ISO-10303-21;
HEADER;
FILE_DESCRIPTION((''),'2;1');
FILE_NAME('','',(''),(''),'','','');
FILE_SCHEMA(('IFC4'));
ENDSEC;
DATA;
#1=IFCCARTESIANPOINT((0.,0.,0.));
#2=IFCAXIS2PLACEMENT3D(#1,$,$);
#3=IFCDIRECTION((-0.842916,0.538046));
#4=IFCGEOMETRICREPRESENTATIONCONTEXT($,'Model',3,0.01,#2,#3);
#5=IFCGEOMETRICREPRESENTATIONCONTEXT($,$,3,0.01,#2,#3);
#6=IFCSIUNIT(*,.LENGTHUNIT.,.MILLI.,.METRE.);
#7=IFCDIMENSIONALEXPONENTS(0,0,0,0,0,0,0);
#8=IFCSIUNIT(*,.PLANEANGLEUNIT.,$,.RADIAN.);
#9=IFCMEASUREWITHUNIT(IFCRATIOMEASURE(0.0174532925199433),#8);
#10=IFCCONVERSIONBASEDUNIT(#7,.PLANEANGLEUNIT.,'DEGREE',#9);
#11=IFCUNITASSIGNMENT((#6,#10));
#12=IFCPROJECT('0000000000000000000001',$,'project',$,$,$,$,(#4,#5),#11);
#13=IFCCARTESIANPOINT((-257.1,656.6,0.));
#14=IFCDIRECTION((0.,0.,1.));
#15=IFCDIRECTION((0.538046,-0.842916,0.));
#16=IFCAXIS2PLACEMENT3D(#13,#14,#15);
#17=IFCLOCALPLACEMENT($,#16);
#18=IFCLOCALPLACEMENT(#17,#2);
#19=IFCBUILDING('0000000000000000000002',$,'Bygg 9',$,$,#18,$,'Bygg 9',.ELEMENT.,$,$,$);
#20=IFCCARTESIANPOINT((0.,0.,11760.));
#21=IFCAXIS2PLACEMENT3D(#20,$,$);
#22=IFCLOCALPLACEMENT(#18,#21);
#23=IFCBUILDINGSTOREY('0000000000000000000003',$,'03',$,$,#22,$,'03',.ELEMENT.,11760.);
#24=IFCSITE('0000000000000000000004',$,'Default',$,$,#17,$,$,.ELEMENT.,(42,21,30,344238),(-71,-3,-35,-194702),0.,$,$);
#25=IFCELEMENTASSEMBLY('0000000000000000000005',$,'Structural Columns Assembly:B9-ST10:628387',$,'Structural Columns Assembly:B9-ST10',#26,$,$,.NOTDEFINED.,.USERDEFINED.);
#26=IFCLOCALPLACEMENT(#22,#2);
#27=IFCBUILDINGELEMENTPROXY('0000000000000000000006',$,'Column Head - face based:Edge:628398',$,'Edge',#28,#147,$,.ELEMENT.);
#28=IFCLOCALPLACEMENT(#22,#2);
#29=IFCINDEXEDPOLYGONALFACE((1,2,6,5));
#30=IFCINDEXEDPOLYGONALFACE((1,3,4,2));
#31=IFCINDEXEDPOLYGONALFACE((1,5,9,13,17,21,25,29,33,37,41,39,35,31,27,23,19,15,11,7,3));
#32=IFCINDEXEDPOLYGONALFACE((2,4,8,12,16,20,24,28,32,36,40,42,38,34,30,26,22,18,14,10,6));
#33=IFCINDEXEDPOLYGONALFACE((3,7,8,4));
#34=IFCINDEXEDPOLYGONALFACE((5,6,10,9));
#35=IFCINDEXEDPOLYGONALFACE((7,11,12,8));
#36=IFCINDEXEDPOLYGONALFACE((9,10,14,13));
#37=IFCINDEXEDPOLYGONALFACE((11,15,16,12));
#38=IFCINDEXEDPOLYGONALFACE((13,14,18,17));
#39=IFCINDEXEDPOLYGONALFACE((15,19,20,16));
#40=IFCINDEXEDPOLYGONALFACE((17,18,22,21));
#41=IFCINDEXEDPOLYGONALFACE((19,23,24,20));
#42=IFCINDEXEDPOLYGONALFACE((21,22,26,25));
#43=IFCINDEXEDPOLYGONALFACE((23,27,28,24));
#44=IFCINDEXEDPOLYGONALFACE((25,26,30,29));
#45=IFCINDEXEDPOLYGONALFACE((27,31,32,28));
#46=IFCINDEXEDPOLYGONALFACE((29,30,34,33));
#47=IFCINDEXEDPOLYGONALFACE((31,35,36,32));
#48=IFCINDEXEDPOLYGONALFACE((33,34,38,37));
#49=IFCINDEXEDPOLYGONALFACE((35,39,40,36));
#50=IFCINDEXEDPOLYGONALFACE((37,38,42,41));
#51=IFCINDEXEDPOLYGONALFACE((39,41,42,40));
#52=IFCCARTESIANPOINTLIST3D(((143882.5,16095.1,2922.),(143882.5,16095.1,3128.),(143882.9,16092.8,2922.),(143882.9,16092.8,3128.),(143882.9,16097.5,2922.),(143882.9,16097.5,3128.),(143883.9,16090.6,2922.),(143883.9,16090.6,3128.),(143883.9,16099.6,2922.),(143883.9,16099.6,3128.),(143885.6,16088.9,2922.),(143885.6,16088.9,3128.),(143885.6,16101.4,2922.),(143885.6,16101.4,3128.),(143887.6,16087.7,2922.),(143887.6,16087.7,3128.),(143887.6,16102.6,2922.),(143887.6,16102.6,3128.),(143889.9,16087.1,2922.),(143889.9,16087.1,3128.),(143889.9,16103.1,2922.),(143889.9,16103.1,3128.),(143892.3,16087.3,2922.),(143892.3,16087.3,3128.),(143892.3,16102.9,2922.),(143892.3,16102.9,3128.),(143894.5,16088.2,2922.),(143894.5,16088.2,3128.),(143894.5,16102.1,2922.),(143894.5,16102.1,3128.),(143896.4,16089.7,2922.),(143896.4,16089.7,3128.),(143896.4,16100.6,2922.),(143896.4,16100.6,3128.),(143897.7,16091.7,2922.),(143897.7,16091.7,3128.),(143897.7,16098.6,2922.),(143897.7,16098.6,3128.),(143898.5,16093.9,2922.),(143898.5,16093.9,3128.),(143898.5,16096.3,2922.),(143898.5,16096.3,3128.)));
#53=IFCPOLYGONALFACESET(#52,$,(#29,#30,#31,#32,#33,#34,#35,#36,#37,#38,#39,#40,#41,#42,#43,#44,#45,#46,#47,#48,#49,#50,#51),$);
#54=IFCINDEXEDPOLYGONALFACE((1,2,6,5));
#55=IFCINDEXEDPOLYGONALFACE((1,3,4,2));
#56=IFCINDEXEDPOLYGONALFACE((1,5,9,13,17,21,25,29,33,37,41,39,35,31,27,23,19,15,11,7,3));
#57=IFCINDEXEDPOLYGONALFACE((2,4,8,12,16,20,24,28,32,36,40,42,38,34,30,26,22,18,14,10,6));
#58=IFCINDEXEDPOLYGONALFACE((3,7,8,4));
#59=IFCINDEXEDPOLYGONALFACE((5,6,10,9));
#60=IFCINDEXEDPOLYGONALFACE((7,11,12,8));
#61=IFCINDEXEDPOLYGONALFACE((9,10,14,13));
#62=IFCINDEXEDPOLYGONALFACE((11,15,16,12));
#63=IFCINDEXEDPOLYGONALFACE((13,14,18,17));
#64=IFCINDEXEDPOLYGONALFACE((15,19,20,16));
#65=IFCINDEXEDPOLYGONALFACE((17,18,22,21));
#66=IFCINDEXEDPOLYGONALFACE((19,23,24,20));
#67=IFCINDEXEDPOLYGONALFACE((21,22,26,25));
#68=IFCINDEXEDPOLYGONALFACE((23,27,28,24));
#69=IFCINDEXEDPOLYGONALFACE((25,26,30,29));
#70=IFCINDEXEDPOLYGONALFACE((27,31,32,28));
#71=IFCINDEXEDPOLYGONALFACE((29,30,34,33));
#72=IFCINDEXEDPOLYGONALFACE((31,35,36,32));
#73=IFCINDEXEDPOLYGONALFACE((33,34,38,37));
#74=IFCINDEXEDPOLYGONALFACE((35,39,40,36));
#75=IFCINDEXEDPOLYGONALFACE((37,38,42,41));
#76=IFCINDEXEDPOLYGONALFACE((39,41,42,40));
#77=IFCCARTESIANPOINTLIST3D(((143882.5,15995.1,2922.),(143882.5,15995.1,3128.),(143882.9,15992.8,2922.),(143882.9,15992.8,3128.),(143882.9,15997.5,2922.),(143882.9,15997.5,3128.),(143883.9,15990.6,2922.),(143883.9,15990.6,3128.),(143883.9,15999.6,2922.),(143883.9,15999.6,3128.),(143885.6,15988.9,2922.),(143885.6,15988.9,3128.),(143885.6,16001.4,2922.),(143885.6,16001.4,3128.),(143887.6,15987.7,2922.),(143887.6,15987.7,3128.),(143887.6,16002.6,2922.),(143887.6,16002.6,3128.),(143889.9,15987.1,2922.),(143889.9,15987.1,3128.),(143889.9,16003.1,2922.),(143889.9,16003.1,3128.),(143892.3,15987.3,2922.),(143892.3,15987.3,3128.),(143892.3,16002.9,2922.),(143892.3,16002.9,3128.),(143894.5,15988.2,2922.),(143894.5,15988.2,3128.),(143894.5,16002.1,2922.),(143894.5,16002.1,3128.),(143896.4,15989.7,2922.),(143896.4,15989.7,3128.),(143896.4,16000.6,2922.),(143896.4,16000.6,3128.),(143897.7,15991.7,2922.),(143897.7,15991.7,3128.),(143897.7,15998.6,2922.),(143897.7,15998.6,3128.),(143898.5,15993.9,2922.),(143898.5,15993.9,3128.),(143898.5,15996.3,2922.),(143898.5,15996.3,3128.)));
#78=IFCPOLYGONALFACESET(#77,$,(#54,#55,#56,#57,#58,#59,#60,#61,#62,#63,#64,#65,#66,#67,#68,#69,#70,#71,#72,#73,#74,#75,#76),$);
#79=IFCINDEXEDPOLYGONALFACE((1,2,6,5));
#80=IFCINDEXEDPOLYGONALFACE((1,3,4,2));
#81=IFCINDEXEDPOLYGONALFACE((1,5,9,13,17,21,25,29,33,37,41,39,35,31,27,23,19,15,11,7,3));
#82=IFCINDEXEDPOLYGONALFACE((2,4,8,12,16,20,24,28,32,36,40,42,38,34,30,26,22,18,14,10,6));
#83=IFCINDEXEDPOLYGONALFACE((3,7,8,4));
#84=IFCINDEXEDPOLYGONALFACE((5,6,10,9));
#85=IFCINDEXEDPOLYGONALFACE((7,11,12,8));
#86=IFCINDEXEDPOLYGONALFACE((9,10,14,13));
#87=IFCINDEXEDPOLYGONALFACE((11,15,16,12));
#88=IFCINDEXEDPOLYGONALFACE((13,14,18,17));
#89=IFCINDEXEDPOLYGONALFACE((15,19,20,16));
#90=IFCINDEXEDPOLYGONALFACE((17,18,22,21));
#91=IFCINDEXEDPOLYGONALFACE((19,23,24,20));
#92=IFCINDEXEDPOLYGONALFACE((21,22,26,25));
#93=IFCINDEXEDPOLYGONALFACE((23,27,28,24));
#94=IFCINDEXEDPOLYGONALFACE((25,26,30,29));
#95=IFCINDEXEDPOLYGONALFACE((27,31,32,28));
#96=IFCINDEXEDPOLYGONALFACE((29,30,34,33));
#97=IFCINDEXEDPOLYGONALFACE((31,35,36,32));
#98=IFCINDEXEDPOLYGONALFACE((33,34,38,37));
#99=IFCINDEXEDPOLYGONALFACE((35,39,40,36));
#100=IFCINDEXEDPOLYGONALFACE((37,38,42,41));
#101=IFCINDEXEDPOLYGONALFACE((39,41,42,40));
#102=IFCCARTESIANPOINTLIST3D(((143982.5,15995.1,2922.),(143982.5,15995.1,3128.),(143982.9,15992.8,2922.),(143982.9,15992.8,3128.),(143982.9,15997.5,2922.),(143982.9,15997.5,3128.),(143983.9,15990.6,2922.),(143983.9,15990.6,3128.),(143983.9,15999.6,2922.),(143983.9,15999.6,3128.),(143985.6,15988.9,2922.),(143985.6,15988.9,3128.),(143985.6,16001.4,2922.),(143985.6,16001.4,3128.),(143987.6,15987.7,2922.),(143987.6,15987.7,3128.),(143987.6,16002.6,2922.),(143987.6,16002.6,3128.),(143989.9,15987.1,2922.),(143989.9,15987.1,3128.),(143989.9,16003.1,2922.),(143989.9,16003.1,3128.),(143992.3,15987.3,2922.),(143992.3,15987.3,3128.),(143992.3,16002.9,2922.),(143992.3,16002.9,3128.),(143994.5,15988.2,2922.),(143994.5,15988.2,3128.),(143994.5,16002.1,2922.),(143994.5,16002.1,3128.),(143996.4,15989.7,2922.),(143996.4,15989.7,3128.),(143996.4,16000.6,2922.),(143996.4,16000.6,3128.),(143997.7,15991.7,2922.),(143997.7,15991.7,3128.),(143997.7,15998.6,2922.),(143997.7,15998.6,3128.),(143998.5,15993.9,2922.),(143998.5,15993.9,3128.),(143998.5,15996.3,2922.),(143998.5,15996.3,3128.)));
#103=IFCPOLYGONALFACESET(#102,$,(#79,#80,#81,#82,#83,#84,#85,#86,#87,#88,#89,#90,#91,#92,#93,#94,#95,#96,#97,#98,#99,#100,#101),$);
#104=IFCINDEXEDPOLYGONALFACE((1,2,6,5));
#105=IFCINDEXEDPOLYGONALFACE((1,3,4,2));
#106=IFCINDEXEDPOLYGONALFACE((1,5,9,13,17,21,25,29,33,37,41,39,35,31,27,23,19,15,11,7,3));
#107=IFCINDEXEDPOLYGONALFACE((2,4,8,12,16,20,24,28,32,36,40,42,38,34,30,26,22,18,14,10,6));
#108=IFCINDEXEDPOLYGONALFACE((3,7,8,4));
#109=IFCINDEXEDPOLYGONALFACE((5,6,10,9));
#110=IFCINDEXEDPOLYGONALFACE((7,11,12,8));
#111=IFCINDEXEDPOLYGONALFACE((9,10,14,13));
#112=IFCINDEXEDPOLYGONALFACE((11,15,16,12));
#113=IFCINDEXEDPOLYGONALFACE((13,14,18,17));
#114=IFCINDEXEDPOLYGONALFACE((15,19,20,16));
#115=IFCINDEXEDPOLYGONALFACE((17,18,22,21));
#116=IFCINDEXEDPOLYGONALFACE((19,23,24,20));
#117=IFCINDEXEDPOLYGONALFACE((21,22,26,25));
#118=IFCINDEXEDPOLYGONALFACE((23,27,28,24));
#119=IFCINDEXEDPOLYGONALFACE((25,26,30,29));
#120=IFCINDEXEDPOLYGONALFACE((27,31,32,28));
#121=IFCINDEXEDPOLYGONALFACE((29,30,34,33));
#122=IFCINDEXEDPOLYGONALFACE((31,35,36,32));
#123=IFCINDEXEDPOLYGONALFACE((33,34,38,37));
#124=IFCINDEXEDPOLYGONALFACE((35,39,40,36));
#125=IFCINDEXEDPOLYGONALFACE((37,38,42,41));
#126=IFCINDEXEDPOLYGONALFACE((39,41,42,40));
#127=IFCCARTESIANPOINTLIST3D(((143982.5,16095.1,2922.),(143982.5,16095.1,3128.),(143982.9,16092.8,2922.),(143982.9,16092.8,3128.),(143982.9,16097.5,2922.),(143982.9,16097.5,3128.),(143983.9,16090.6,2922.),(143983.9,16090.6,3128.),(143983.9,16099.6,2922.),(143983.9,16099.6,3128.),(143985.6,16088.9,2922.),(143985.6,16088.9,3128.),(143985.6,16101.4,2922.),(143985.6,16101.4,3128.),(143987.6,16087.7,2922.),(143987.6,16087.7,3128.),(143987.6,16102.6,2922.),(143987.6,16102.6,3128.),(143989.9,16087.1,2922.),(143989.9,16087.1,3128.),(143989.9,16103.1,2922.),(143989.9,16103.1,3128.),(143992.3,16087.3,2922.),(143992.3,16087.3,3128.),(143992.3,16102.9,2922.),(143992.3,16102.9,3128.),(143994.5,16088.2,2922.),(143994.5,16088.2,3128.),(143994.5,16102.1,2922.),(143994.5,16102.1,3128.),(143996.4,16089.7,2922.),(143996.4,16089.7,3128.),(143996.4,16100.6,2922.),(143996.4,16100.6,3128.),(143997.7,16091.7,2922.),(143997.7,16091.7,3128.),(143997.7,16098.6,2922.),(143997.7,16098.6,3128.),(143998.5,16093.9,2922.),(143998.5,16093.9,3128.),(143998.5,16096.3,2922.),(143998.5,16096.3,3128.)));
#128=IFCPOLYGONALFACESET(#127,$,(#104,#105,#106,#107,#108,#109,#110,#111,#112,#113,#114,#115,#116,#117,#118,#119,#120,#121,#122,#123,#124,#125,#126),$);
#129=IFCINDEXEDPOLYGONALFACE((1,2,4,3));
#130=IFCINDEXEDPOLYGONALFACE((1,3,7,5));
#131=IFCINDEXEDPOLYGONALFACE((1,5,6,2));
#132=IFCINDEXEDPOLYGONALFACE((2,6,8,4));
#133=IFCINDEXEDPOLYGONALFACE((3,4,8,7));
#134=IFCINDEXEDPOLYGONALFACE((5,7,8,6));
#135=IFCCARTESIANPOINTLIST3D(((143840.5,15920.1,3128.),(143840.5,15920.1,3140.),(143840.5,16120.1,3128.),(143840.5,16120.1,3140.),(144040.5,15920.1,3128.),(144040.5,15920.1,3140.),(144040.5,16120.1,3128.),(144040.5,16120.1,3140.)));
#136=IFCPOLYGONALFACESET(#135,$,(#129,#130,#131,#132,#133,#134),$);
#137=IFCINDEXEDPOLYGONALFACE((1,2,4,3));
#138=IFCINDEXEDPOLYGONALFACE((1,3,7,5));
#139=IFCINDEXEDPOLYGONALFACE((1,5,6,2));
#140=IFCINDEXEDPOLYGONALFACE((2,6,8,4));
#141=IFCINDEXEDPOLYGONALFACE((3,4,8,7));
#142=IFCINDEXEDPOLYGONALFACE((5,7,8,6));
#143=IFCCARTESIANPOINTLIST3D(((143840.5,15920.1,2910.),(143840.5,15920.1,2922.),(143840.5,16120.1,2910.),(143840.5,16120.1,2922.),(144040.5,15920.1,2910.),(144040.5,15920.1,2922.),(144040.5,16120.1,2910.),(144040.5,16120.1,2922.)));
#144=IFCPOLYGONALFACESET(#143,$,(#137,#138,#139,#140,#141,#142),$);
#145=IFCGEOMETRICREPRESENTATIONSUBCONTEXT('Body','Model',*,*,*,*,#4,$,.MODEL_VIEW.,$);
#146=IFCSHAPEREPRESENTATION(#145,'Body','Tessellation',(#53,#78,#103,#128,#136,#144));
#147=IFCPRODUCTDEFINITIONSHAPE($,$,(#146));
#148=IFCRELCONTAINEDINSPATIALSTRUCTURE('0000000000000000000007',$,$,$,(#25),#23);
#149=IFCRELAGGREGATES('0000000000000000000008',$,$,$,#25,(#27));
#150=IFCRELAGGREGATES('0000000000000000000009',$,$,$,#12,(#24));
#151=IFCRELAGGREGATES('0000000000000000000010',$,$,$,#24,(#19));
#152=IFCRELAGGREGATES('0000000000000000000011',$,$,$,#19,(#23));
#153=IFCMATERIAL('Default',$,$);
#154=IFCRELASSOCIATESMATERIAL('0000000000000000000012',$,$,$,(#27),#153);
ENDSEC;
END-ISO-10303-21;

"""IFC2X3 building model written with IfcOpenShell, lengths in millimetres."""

from ifc_helpers import new_model, entity, si_unit, converted_unit, direction, frame, frame_2d, origin, origin_2d_with_axis, place, context, subcontext, project, spatial, rectangle, circle, extrude, source, transform, mapped, material, element, aggregate, save


model = new_model("IFC2X3")

# Units and contexts
model_context = context("Model", 3, precision=0.01, world=origin(), true_north=direction((-0.842916, 0.538046)))
context_of_model = context(None, 3, precision=0.01, world=origin(), true_north=direction((-0.842916, 0.538046)))
body_context = subcontext(model_context, "Body", "Model", "MODEL_VIEW")
ifc_project = project(units=[si_unit("LENGTHUNIT", "METRE", prefix="MILLI"), converted_unit("PLANEANGLEUNIT", "DEGREE", entity("IfcRatioMeasure", 0.0174532925199433), si_unit("PLANEANGLEUNIT", "RADIAN"), dimensions=[0, 0, 0, 0, 0, 0, 0])], contexts=[model_context, context_of_model])

# Site, building, storey
site_placement = place(None, frame((-257.1, 656.6, 0.0), z_axis=(0.0, 0.0, 1.0), x_axis=(0.538046, -0.842916, 0.0)))
site = spatial("IfcSite", under=ifc_project, at=site_placement, Name="Default", CompositionType="ELEMENT", RefLatitude=(42, 21, 30, 344238), RefLongitude=(-71, -3, -35, -194702), RefElevation=0.0)
building_placement = place(site_placement, origin())
building = spatial("IfcBuilding", under=site, at=building_placement, Name="Bygg 9", LongName="Bygg 9", CompositionType="ELEMENT")
storey_placement = place(building_placement, frame((0.0, 0.0, 11760.0)))
storey = spatial("IfcBuildingStorey", under=building, at=storey_placement, Name="03", LongName="03", CompositionType="ELEMENT", Elevation=11760.0)

# Element assembly
assembly_1_placement = place(storey_placement, origin())
assembly_1 = element("IfcElementAssembly", 1, at=assembly_1_placement, inside=storey, Name="Structural Columns Assembly:B9-ST10:628387", ObjectType="Structural Columns Assembly:B9-ST10", AssemblyPlace="NOTDEFINED", PredefinedType="USERDEFINED")

# Building element proxy
ifc_material_1 = material(Name="Default")
shared_shape_1 = source(origin(), body_context, "Body", "SweptSolid", [
    extrude(circle(Radius=8.0, at=frame_2d((0.0, 0.0), x_axis=(1.0, 0.0))), frame((50.0, -75.0, 12.0)), (0.0, 0.0, 1.0), 206.0),
    extrude(circle(Radius=8.0, at=frame_2d((0.0, 0.0), x_axis=(1.0, 0.0))), frame((50.0, 25.0, 12.0)), (0.0, 0.0, 1.0), 206.0),
    extrude(circle(Radius=8.0, at=frame_2d((0.0, 0.0), x_axis=(1.0, 0.0))), frame((-50.0, 25.0, 12.0)), (0.0, 0.0, 1.0), 206.0),
    extrude(circle(Radius=8.0, at=frame_2d((0.0, 0.0), x_axis=(1.0, 0.0))), frame((-50.0, -75.0, 12.0)), (0.0, 0.0, 1.0), 206.0),
    extrude(rectangle(XDim=200.0, YDim=200.0, at=origin_2d_with_axis()), frame((0.0, 0.0, 218.0), z_axis=(0.0, 0.0, 1.0), x_axis=(-1.0, 0.0, 0.0)), (0.0, 0.0, 1.0), 12.0),
    extrude(rectangle(XDim=200.0, YDim=200.0, at=origin_2d_with_axis()), frame((0.0, 0.0, 0.0), z_axis=(0.0, 0.0, 1.0), x_axis=(0.0, 1.0, 0.0)), (0.0, 0.0, 1.0), 12.0),
])
proxy_1_placement = place(assembly_1_placement, frame((143940.5, 16020.1, 2910.0), z_axis=(0.0, 0.0, 1.0), x_axis=(-1.0, 0.0, 0.0)))
proxy_1 = element("IfcBuildingElementProxy", 2, at=proxy_1_placement, material=ifc_material_1, Name="Column Head - face based:Edge:628398", ObjectType="Edge", CompositionType="ELEMENT", context=body_context, shape_type="MappedRepresentation", body=[
    mapped(shared_shape_1, transform((0.0, 0.0, 0.0), scale=1.0)),
])
aggregate(assembly_1, [proxy_1])

save(model, "model.ifc")
